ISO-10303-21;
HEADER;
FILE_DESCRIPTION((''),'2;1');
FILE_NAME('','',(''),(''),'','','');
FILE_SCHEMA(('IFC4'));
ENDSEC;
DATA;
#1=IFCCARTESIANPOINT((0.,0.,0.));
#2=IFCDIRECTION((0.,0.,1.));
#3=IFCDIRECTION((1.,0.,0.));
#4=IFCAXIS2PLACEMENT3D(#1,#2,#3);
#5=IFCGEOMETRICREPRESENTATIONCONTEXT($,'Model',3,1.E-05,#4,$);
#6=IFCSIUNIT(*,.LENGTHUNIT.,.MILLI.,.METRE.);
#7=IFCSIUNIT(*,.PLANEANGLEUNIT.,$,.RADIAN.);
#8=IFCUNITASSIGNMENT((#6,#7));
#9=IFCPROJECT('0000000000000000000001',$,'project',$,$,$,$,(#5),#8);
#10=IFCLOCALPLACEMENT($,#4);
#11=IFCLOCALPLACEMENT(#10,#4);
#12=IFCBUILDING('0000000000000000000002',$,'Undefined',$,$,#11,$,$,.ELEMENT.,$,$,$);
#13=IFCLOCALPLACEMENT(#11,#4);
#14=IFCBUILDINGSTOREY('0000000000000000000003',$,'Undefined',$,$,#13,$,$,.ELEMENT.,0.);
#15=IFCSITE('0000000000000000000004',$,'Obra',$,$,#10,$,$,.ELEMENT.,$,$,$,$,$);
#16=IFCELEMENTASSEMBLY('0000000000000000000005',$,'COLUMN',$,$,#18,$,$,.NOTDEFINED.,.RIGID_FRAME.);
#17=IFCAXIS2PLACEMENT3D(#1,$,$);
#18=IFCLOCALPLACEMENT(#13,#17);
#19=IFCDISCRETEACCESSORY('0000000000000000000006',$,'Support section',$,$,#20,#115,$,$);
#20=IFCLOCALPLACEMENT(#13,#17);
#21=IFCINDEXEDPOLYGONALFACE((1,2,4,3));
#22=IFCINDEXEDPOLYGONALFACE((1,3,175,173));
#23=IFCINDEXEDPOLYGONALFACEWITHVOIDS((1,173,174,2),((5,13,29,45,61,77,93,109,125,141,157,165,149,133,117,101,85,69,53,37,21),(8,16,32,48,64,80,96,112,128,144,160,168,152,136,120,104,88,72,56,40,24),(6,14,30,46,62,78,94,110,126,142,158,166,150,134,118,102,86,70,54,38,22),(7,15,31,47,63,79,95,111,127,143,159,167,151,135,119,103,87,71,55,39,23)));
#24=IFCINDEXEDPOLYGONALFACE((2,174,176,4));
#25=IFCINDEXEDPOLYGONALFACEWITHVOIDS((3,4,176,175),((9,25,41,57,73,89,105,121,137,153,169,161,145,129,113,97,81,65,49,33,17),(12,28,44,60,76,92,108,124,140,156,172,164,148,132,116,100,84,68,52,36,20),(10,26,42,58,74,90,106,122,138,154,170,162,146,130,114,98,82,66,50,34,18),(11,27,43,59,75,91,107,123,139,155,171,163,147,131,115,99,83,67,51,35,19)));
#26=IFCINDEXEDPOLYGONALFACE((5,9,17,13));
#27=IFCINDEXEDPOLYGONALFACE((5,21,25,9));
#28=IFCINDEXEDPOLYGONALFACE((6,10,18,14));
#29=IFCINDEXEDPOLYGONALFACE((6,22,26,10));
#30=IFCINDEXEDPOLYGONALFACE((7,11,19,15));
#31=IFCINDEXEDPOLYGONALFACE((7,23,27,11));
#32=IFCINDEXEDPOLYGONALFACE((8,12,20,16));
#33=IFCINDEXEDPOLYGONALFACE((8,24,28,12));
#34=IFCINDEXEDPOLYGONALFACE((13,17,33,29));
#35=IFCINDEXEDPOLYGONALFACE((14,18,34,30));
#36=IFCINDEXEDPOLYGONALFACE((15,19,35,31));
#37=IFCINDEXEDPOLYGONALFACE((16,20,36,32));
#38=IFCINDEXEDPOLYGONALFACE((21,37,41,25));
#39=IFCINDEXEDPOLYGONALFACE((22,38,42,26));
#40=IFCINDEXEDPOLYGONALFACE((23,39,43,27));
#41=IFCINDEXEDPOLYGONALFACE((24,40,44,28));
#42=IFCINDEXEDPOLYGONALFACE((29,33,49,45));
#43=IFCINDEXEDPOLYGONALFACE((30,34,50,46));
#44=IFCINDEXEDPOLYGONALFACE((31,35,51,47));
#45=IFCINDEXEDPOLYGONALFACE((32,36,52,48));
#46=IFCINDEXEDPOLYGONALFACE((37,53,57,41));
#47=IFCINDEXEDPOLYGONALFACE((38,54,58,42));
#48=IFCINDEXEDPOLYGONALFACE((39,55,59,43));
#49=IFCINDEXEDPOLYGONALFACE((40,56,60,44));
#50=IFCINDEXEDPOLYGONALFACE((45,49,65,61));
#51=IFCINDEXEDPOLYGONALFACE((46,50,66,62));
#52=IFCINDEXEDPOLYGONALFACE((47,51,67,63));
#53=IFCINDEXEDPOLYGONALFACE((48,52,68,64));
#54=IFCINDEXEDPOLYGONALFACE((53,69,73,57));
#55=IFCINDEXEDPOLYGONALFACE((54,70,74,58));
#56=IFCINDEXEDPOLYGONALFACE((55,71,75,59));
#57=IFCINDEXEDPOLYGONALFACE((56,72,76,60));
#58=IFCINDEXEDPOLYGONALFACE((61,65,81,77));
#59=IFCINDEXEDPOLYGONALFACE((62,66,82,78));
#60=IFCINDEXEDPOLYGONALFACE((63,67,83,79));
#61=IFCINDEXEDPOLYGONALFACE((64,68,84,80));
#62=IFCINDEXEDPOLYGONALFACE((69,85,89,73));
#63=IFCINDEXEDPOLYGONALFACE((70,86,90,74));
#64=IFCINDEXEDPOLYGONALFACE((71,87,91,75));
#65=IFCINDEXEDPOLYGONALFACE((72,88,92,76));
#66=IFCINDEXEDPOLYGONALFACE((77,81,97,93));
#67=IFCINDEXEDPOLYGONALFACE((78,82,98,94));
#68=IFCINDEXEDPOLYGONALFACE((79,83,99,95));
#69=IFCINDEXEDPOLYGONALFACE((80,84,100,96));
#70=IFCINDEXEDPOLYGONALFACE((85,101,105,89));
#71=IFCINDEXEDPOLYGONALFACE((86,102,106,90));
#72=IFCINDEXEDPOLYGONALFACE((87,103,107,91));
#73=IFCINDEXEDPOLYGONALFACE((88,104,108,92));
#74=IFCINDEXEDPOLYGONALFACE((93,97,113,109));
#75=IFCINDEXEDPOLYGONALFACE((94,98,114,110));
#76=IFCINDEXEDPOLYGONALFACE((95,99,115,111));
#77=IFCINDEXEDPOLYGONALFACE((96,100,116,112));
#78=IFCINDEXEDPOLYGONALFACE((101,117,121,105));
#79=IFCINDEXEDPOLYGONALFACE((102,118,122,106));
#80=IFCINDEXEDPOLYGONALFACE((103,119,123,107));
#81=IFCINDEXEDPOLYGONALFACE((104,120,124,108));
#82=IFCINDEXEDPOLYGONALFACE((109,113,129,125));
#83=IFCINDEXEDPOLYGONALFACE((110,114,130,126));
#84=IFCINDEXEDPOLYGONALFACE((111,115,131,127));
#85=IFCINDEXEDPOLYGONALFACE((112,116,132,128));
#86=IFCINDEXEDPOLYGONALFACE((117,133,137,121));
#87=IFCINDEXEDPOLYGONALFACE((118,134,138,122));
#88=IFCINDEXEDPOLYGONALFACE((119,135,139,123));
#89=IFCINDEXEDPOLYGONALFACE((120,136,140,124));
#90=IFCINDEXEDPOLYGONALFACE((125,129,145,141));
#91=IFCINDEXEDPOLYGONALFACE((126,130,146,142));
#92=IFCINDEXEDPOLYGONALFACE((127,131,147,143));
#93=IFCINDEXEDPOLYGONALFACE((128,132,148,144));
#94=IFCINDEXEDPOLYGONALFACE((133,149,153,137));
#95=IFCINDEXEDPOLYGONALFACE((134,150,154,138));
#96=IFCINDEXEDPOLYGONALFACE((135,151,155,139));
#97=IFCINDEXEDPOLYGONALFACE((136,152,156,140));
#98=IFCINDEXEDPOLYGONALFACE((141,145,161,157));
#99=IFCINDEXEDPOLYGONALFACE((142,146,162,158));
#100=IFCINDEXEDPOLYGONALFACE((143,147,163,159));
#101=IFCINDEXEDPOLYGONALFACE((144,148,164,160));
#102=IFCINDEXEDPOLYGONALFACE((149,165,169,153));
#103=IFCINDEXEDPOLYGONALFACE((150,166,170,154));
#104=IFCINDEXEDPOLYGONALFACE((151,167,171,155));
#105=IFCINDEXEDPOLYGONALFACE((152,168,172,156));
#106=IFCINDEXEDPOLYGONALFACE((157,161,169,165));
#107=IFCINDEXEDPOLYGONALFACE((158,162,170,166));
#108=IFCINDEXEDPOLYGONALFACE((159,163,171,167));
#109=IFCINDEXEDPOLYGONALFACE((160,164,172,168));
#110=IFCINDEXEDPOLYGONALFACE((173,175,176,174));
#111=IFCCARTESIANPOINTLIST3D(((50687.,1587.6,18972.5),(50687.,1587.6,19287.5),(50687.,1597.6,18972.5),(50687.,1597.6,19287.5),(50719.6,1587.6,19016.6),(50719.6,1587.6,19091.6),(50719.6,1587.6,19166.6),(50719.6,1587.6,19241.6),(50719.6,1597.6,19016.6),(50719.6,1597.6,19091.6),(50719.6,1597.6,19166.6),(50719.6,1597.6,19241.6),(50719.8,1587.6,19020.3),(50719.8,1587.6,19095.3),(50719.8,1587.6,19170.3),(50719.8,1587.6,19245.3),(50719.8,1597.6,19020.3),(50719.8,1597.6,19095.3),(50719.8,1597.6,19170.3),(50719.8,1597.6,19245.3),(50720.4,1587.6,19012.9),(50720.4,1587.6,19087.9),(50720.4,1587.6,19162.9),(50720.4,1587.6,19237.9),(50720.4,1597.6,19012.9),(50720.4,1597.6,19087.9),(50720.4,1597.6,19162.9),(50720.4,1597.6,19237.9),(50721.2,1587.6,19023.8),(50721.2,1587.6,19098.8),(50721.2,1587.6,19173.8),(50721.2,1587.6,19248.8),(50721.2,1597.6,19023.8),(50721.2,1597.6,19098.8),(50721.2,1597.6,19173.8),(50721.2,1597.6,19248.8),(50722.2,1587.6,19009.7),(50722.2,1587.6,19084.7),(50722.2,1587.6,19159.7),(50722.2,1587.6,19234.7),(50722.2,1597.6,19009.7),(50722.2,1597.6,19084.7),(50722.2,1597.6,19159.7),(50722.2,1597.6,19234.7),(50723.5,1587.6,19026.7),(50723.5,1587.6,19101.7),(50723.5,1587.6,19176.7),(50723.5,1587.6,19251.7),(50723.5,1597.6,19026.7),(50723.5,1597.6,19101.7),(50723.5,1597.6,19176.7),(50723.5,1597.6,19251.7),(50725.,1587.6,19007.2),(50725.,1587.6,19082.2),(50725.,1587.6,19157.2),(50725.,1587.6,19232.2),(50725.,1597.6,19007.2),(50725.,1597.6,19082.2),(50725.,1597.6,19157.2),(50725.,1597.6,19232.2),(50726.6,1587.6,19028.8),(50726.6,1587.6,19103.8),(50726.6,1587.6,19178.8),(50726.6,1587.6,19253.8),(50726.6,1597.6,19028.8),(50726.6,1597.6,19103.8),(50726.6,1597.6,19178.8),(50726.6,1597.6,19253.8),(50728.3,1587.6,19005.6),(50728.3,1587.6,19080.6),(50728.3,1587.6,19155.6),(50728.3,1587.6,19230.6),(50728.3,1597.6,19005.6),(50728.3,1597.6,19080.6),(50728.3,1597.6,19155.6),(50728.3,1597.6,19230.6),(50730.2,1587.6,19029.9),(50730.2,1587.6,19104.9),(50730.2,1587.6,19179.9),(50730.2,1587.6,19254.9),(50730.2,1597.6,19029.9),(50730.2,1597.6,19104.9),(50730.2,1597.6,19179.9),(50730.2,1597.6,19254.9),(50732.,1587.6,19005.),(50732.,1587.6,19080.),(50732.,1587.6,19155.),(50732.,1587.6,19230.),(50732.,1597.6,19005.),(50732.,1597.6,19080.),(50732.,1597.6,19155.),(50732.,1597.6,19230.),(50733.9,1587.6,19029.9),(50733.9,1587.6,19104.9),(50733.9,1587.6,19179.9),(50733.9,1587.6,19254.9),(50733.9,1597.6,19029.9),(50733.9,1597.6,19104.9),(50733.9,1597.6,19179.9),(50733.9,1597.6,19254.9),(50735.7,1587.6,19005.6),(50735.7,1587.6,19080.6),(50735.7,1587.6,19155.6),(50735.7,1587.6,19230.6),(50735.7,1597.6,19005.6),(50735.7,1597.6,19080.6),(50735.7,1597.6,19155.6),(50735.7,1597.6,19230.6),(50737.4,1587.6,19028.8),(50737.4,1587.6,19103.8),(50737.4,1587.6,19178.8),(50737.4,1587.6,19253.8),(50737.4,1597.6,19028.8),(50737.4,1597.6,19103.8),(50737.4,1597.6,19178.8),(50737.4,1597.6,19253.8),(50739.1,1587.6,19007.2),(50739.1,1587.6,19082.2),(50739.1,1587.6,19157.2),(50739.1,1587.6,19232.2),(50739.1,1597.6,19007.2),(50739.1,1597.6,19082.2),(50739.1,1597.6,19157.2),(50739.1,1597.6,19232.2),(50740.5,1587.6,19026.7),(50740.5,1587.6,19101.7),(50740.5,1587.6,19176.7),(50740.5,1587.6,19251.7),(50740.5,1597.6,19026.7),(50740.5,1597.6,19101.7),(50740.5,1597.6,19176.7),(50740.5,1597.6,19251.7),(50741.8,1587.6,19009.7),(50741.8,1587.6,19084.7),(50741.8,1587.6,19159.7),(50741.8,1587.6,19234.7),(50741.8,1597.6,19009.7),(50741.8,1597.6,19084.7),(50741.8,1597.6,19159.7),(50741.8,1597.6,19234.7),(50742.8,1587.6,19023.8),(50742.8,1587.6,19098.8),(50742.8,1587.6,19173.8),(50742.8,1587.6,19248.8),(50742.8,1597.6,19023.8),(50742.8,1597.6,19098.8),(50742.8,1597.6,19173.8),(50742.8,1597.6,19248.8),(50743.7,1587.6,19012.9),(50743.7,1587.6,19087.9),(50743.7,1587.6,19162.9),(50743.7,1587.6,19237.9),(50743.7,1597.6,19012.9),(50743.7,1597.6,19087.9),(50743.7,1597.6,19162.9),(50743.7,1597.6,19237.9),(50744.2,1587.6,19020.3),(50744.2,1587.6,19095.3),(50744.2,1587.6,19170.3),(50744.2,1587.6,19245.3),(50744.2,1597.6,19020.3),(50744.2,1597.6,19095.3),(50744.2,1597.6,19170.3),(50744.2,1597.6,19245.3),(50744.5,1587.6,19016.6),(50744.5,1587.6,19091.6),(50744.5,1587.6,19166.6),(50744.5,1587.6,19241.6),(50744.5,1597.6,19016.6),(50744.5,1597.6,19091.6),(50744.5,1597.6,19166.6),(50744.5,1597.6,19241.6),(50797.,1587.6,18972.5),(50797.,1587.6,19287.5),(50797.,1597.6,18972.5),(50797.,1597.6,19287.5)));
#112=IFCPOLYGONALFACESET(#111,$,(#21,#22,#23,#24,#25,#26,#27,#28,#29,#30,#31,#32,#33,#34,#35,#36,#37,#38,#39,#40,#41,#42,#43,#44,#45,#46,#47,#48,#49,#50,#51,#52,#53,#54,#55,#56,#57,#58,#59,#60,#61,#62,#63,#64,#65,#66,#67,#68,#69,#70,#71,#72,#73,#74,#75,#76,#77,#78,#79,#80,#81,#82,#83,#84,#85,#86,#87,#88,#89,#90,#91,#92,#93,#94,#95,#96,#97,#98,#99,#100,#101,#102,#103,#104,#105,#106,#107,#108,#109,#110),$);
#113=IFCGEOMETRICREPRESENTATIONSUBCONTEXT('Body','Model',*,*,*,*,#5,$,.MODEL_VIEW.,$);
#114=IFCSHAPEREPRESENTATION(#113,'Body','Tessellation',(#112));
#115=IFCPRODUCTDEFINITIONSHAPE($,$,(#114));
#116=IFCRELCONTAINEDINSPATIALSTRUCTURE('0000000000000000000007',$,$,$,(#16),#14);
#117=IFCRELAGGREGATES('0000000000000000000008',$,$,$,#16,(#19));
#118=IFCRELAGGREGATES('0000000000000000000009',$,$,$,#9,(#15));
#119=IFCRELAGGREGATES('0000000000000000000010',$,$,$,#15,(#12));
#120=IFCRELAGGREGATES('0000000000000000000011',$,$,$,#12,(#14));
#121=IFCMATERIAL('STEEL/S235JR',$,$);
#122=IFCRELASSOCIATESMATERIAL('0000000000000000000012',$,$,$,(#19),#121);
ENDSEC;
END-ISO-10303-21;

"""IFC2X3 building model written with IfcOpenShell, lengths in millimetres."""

from ifc_helpers import new_model, si_unit, frame, origin_with_axes, origin_2d_with_axis, place, context, subcontext, project, spatial, rectangle, circle, extrude, source, transform, mapped, material, element, aggregate, save


model = new_model("IFC2X3")

# Units and contexts
model_context = context("Model", 3, precision=1e-05, world=origin_with_axes())
body_context = subcontext(model_context, "Body", "Model", "MODEL_VIEW")
ifc_project = project(units=[si_unit("LENGTHUNIT", "METRE", prefix="MILLI"), si_unit("PLANEANGLEUNIT", "RADIAN")], contexts=[model_context])

# Site, building, storey
site_placement = place(None, origin_with_axes())
site = spatial("IfcSite", under=ifc_project, at=site_placement, Name="Obra", CompositionType="ELEMENT")
building_placement = place(site_placement, origin_with_axes())
building = spatial("IfcBuilding", under=site, at=building_placement, Name="Undefined", CompositionType="ELEMENT")
storey_placement = place(building_placement, origin_with_axes())
storey = spatial("IfcBuildingStorey", under=building, at=storey_placement, Name="Undefined", CompositionType="ELEMENT", Elevation=0.0)

# Shared definitions
ifc_material_1 = material(Name="STEEL/S235JR")

# Element assembly, discrete accessory, opening
assembly_1_placement = place(storey_placement, origin_with_axes())
assembly_1 = element("IfcElementAssembly", 1, at=assembly_1_placement, inside=storey, Name="COLUMN", AssemblyPlace="NOTDEFINED", PredefinedType="RIGID_FRAME")
shared_shape_1 = source(origin_with_axes(), body_context, "Body", "SweptSolid", [
    extrude(circle(Radius=12.5, at=origin_2d_with_axis()), frame((0.0, 5.7, 0.0), z_axis=(0.0, 1.0, 0.0), x_axis=(1.0, 0.0, 0.0)), (0.0, 0.0, 1.0), 10.2),
])
discrete_accessory_1_placement = place(assembly_1_placement, frame((50742.0, 1592.6, 18972.5), z_axis=(0.0, 0.0, 1.0), x_axis=(1.0, 0.0, 0.0)))
discrete_accessory_1 = element("IfcDiscreteAccessory", 2, at=discrete_accessory_1_placement, material=ifc_material_1, Name="Support section", context=body_context, shape_type="SweptSolid", body=[
    extrude(rectangle(XDim=10.0, YDim=110.0, at=origin_2d_with_axis()), frame((0.0, 0.0, 315.0), z_axis=(0.0, 0.0, -1.0), x_axis=(0.0, 1.0, 0.0)), (0.0, 0.0, 1.0), 315.0),
])
opening_1_placement = place(assembly_1_placement, frame((50777.0, 1603.4, 19350.0), z_axis=(-1.0, 0.0, 0.0), x_axis=(0.0, 0.0, -1.0)))
element("IfcOpeningElement", 3, at=opening_1_placement, cuts=discrete_accessory_1, ObjectType="Opening", context=body_context, shape_type="MappedRepresentation", body=[
    mapped(shared_shape_1, transform((107.5, 0.0, 45.0))),
    mapped(shared_shape_1, transform((182.5, 0.0, 45.0))),
    mapped(shared_shape_1, transform((257.5, 0.0, 45.0))),
    mapped(shared_shape_1, transform((332.5, 0.0, 45.0))),
])

aggregate(assembly_1, [discrete_accessory_1])

save(model, "model.ifc")
